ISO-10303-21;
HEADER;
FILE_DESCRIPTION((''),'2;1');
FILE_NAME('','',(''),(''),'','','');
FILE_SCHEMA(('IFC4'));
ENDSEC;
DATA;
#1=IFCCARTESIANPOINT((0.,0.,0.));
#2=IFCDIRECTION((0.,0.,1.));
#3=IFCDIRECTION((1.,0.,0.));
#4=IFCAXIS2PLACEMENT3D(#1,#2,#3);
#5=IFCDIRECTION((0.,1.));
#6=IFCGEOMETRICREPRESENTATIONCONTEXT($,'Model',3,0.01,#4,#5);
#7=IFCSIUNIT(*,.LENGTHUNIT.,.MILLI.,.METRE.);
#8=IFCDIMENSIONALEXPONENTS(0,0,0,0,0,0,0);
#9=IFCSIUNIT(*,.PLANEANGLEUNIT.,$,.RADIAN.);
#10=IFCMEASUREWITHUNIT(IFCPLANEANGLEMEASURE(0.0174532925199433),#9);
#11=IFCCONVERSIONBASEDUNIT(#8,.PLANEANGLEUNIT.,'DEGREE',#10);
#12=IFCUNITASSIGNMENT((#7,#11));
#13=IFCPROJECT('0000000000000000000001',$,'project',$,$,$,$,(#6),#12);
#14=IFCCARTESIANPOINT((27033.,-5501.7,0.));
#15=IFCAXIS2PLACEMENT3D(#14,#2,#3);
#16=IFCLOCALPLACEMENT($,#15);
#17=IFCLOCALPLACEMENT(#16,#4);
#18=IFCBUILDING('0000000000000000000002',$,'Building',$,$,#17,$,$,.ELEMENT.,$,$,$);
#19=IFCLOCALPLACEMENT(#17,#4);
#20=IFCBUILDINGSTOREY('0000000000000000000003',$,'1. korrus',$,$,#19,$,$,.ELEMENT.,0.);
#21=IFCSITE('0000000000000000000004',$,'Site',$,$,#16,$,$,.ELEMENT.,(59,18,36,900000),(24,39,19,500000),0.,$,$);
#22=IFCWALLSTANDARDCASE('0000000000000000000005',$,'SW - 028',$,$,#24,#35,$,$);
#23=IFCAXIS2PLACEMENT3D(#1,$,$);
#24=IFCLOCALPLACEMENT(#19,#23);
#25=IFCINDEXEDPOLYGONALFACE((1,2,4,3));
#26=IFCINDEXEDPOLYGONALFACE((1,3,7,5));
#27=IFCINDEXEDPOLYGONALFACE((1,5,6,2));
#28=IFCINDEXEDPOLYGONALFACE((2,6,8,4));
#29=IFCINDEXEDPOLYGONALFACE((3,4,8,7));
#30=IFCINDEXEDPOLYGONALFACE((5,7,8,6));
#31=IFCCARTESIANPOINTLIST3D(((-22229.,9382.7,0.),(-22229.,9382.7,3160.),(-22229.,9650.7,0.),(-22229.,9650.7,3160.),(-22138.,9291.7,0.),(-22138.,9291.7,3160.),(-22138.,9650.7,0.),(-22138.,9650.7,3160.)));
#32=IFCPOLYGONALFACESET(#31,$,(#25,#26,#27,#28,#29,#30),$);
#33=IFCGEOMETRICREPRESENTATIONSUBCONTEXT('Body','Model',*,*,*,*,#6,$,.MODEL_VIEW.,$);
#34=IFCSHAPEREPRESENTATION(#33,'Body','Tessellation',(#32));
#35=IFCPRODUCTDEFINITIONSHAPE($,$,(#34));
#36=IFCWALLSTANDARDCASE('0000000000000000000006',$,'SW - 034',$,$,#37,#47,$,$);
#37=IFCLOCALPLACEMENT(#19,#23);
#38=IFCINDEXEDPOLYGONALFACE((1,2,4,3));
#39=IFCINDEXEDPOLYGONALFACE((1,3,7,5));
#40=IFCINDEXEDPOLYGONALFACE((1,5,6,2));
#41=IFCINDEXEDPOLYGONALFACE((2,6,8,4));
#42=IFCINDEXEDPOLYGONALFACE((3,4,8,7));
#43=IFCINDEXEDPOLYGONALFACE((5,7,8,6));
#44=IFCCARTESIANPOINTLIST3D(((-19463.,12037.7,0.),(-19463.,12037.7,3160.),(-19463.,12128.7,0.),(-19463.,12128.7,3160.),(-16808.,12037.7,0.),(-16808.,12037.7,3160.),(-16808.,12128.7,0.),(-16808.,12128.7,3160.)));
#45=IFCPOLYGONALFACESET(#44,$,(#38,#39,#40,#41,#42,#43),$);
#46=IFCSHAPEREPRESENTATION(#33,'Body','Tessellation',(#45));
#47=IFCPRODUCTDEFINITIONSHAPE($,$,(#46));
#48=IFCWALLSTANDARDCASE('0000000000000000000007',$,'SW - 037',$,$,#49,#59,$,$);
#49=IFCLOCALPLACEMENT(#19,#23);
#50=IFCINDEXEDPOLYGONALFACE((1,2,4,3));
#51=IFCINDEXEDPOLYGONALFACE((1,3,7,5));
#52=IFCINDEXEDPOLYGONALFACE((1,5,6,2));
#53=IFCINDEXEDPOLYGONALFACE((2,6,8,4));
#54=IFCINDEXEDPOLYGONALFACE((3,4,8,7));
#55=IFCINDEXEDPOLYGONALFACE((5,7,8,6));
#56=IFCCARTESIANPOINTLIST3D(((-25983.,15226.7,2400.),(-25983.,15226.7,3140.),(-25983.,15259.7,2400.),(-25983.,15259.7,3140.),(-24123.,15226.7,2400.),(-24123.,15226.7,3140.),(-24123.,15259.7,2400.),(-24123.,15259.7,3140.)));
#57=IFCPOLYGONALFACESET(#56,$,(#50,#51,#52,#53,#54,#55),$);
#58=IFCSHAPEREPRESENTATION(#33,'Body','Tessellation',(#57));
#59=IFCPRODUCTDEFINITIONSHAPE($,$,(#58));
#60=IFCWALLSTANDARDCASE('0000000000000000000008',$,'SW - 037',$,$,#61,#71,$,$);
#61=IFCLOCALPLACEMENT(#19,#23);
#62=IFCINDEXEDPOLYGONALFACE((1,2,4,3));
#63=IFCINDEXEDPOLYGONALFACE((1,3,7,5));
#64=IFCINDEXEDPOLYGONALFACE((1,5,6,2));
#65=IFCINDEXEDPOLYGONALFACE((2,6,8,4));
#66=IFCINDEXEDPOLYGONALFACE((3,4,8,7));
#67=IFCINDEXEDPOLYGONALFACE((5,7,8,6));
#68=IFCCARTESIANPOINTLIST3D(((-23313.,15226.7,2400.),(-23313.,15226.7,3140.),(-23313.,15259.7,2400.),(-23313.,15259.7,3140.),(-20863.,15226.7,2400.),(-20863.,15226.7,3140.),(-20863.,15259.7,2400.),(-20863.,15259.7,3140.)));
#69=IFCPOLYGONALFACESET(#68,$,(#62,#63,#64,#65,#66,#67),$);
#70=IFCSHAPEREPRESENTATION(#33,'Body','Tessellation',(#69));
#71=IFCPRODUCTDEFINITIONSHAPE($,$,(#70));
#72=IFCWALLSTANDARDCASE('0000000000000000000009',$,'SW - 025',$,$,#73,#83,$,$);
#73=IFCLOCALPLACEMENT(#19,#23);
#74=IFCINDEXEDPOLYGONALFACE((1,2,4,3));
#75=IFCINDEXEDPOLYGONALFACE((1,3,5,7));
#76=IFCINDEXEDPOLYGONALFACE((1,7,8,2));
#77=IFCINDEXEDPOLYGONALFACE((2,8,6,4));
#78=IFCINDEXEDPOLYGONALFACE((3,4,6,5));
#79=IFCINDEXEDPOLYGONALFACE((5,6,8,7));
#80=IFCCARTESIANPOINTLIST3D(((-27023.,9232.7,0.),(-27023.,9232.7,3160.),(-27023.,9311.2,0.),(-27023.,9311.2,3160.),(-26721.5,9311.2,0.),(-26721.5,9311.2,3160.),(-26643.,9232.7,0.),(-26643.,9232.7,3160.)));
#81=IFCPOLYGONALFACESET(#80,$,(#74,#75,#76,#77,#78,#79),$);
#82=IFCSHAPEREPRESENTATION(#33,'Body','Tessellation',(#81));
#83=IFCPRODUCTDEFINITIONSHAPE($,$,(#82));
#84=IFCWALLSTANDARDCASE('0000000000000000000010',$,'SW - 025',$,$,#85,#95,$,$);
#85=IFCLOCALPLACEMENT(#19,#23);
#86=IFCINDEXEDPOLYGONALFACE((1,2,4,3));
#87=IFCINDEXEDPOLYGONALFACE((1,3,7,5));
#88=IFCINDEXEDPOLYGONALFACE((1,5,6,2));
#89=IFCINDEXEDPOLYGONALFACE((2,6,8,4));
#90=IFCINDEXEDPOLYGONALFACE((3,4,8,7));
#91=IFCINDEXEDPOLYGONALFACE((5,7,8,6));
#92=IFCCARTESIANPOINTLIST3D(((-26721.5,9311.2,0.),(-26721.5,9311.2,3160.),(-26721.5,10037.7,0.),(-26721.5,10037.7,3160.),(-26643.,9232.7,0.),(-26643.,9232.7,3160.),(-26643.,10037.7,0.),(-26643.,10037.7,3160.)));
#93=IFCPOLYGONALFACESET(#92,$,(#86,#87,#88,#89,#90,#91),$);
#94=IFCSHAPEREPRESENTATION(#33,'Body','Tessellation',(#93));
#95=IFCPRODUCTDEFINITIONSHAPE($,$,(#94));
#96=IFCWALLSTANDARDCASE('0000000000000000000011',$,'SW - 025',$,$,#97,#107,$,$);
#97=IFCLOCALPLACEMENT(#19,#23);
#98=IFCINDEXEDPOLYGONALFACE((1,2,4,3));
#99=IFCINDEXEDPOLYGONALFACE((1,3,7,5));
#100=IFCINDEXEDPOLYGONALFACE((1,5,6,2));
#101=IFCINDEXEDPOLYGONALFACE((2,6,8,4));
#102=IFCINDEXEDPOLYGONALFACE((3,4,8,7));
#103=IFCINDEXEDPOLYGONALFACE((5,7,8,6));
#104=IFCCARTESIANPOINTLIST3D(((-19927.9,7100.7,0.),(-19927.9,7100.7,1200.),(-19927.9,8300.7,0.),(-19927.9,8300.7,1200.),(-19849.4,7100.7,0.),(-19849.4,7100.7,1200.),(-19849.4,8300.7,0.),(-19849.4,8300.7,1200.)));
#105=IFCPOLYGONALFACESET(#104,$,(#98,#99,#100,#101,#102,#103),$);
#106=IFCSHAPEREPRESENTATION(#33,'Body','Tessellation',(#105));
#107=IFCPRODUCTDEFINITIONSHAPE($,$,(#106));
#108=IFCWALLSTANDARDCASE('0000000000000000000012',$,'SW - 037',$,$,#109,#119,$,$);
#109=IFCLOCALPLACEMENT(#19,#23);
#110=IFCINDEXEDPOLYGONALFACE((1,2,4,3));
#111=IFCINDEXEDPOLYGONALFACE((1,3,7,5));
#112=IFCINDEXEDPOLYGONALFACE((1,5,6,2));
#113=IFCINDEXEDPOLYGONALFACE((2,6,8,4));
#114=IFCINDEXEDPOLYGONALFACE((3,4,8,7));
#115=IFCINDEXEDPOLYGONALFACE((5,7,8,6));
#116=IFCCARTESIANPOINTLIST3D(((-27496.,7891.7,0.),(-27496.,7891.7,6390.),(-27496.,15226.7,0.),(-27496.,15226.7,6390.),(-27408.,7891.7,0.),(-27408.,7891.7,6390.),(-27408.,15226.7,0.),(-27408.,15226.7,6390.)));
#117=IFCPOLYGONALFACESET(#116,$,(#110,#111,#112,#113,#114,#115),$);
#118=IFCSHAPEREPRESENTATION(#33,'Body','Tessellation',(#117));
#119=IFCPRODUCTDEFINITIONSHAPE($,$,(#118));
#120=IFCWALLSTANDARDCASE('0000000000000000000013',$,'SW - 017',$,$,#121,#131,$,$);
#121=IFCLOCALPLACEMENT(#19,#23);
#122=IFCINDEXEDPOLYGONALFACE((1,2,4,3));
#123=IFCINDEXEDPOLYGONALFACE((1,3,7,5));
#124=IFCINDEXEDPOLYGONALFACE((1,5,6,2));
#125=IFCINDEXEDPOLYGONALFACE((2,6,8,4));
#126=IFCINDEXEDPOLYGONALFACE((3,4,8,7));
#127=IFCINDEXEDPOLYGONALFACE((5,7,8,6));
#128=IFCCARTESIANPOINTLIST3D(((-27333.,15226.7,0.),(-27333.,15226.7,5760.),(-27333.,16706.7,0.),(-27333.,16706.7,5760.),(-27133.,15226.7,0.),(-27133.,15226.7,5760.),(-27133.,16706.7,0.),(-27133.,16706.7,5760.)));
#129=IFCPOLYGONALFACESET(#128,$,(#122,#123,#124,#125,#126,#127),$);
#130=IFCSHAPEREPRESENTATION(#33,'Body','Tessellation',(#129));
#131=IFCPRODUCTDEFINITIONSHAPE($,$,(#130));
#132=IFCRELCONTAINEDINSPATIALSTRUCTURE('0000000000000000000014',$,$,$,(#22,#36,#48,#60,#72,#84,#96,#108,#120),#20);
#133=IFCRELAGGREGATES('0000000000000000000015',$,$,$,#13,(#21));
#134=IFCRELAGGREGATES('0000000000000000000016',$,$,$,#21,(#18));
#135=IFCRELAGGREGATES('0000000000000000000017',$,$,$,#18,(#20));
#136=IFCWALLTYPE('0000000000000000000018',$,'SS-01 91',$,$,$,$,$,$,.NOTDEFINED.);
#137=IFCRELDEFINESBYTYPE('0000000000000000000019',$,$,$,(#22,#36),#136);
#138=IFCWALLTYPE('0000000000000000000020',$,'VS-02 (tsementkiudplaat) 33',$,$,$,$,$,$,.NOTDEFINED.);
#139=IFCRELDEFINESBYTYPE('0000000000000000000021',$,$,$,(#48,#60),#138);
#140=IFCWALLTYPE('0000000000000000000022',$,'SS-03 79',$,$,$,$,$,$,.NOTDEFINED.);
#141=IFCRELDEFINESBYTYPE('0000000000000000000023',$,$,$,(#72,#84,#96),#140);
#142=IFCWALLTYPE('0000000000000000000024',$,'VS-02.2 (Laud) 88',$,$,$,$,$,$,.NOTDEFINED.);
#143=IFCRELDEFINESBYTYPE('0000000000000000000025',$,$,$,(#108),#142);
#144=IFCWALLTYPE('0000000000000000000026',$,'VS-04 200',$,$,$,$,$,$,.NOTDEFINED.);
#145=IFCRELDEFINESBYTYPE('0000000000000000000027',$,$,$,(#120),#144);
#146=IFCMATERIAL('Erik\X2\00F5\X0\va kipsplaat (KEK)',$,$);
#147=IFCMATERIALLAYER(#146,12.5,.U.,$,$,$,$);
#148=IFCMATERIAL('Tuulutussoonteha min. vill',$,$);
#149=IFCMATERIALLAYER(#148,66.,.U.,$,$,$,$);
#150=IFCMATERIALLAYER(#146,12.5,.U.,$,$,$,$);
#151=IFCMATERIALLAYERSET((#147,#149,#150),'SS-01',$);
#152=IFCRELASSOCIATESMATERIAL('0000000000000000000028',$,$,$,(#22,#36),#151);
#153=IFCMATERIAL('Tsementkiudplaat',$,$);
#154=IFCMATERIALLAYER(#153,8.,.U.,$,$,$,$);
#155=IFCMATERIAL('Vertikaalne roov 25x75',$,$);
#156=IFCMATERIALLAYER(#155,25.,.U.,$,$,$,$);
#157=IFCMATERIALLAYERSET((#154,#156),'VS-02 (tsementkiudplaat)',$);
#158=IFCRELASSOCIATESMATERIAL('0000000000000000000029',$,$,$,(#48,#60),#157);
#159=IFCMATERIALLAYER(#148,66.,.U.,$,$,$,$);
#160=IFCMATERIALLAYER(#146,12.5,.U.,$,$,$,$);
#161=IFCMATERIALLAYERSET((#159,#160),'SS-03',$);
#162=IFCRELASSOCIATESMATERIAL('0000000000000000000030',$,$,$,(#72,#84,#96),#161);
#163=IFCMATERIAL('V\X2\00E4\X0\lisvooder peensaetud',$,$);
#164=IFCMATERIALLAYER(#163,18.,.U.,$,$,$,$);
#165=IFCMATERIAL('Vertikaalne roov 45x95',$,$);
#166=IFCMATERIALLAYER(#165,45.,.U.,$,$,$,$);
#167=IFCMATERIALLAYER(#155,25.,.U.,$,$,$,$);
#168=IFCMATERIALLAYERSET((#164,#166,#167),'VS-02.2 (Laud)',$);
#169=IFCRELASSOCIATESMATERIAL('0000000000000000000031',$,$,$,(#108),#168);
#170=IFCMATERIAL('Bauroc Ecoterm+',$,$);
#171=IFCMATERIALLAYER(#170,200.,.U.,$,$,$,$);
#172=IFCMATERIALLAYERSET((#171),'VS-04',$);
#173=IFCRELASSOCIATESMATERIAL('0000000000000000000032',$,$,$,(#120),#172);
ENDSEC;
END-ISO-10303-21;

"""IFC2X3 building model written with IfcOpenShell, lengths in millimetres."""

from ifc_helpers import new_model, entity, si_unit, converted_unit, direction, frame, origin_with_axes, place, context, subcontext, project, spatial, polyline, outline, extrude, material, layer, layer_set, layer_usage, type_object, element, save


model = new_model("IFC2X3")

# Units and contexts
model_context = context("Model", 3, precision=0.01, world=origin_with_axes(), true_north=direction((0.0, 1.0)))
body_context = subcontext(model_context, "Body", "Model", "MODEL_VIEW")
ifc_project = project(units=[si_unit("LENGTHUNIT", "METRE", prefix="MILLI"), converted_unit("PLANEANGLEUNIT", "DEGREE", entity("IfcPlaneAngleMeasure", 0.0174532925199433), si_unit("PLANEANGLEUNIT", "RADIAN"), dimensions=[0, 0, 0, 0, 0, 0, 0])], contexts=[model_context])

# Site, building, storey
site_placement = place(None, frame((27033.0, -5501.7, 0.0), z_axis=(0.0, 0.0, 1.0), x_axis=(1.0, 0.0, 0.0)))
site = spatial("IfcSite", under=ifc_project, at=site_placement, Name="Site", CompositionType="ELEMENT", RefLatitude=(59, 18, 36, 900000), RefLongitude=(24, 39, 19, 500000), RefElevation=0.0)
building_placement = place(site_placement, origin_with_axes())
building = spatial("IfcBuilding", under=site, at=building_placement, Name="Building", CompositionType="ELEMENT")
storey_placement = place(building_placement, origin_with_axes())
storey = spatial("IfcBuildingStorey", under=building, at=storey_placement, Name="1. korrus", CompositionType="ELEMENT", Elevation=0.0)

# Shared definitions
ifc_material_1 = material(Name="Bauroc Ecoterm+")

# Walls
ifc_material_2 = material(Name="Vertikaalne roov 45x95")
ifc_material_3 = material(Name="Erikõva kipsplaat (KEK)")
ifc_layer_1 = layer(ifc_material_3, 12.5, ventilated="UNKNOWN")
ifc_material_4 = material(Name="Tuulutussoonteha min. vill")
ifc_layer_2 = layer(ifc_material_4, 66.0, ventilated="UNKNOWN")
ifc_layer_3 = layer(ifc_material_3, 12.5, ventilated="UNKNOWN")
ifc_layer_set_1 = layer_set([ifc_layer_1, ifc_layer_2, ifc_layer_3], Name="SS-01")
wall_type_1 = type_object("IfcWallType", Name="SS-01 91", PredefinedType="NOTDEFINED")
ifc_layer_usage_1 = layer_usage(ifc_layer_set_1, "AXIS2", "NEGATIVE", 91.0)
wall_1_placement = place(storey_placement, frame((-22138.0, 9291.7, 0.0), z_axis=(0.0, 0.0, 1.0), x_axis=(0.0, 1.0, 0.0)))
element("IfcWallStandardCase", 1, at=wall_1_placement, inside=storey, type_object=wall_type_1, material=ifc_layer_usage_1, Name="SW - 028", context=body_context, shape_type="SweptSolid", body=[
    extrude(outline(polyline([(0.0, 0.0), (359.0, 0.0), (359.0, 91.0), (91.0, 91.0), (0.0, 0.0)])), origin_with_axes(), (0.0, 0.0, 1.0), 3160.0),
])
ifc_layer_usage_2 = layer_usage(ifc_layer_set_1, "AXIS2", "NEGATIVE", 91.0)
wall_2_placement = place(storey_placement, frame((-19463.0, 12037.7, 0.0), z_axis=(0.0, 0.0, 1.0), x_axis=(1.0, 0.0, 0.0)))
element("IfcWallStandardCase", 2, at=wall_2_placement, inside=storey, type_object=wall_type_1, material=ifc_layer_usage_2, Name="SW - 034", context=body_context, shape_type="SweptSolid", body=[
    extrude(outline(polyline([(0.0, 0.0), (2655.0, 0.0), (2655.0, 91.0), (0.0, 91.0), (0.0, 0.0)])), origin_with_axes(), (0.0, 0.0, 1.0), 3160.0),
])
ifc_material_5 = material(Name="Tsementkiudplaat")
ifc_layer_4 = layer(ifc_material_5, 8.0, ventilated="UNKNOWN")
ifc_material_6 = material(Name="Vertikaalne roov 25x75")
ifc_layer_5 = layer(ifc_material_6, 25.0, ventilated="UNKNOWN")
ifc_layer_set_2 = layer_set([ifc_layer_4, ifc_layer_5], Name="VS-02 (tsementkiudplaat)")
ifc_layer_usage_3 = layer_usage(ifc_layer_set_2, "AXIS2", "POSITIVE", -33.0)
wall_type_2 = type_object("IfcWallType", Name="VS-02 (tsementkiudplaat) 33", PredefinedType="NOTDEFINED")
wall_3_placement = place(storey_placement, frame((-24123.0, 15226.7, 2400.0), z_axis=(0.0, 0.0, 1.0), x_axis=(-1.0, -0.000005, 0.0)))
element("IfcWallStandardCase", 3, at=wall_3_placement, inside=storey, type_object=wall_type_2, material=ifc_layer_usage_3, Name="SW - 037", context=body_context, shape_type="SweptSolid", body=[
    extrude(outline(polyline([(0.0, -33.0), (1860.0, -33.0), (1860.0, 0.0), (0.0, 0.0), (0.0, -33.0)])), origin_with_axes(), (0.0, 0.0, 1.0), 740.0),
])
ifc_layer_usage_4 = layer_usage(ifc_layer_set_2, "AXIS2", "POSITIVE", -33.0)
wall_4_placement = place(storey_placement, frame((-20863.0, 15226.7, 2400.0), z_axis=(0.0, 0.0, 1.0), x_axis=(-1.0, -0.000003, 0.0)))
element("IfcWallStandardCase", 4, at=wall_4_placement, inside=storey, type_object=wall_type_2, material=ifc_layer_usage_4, Name="SW - 037", context=body_context, shape_type="SweptSolid", body=[
    extrude(outline(polyline([(0.0, -33.0), (2450.0, -33.0), (2450.0, 0.0), (0.0, 0.0), (0.0, -33.0)])), origin_with_axes(), (0.0, 0.0, 1.0), 740.0),
])
ifc_layer_6 = layer(ifc_material_4, 66.0, ventilated="UNKNOWN")
ifc_layer_7 = layer(ifc_material_3, 12.5, ventilated="UNKNOWN")
ifc_layer_set_3 = layer_set([ifc_layer_6, ifc_layer_7], Name="SS-03")
ifc_layer_usage_5 = layer_usage(ifc_layer_set_3, "AXIS2", "POSITIVE", -78.5)
wall_type_3 = type_object("IfcWallType", Name="SS-03 79", PredefinedType="NOTDEFINED")
wall_5_placement = place(storey_placement, frame((-26643.0, 9232.7, 0.0), z_axis=(0.0, 0.0, 1.0), x_axis=(-1.0, 0.0, 0.0)))
element("IfcWallStandardCase", 5, at=wall_5_placement, inside=storey, type_object=wall_type_3, material=ifc_layer_usage_5, Name="SW - 025", context=body_context, shape_type="SweptSolid", body=[
    extrude(outline(polyline([(78.5, -78.5), (380.0, -78.5), (380.0, 0.0), (0.0, 0.0), (78.5, -78.5)])), origin_with_axes(), (0.0, 0.0, 1.0), 3160.0),
])
ifc_layer_usage_6 = layer_usage(ifc_layer_set_3, "AXIS2", "NEGATIVE", 78.5)
wall_6_placement = place(storey_placement, frame((-26643.0, 9232.7, 0.0), z_axis=(0.0, 0.0, 1.0), x_axis=(0.0, 1.0, 0.0)))
element("IfcWallStandardCase", 6, at=wall_6_placement, inside=storey, type_object=wall_type_3, material=ifc_layer_usage_6, Name="SW - 025", context=body_context, shape_type="SweptSolid", body=[
    extrude(outline(polyline([(0.0, 0.0), (805.0, 0.0), (805.0, 78.5), (78.5, 78.5), (0.0, 0.0)])), origin_with_axes(), (0.0, 0.0, 1.0), 3160.0),
])
ifc_layer_usage_7 = layer_usage(ifc_layer_set_3, "AXIS2", "POSITIVE", -78.5)
wall_7_placement = place(storey_placement, frame((-19927.9, 7100.7, 0.0), z_axis=(0.0, 0.0, 1.0), x_axis=(0.0, 1.0, 0.0)))
element("IfcWallStandardCase", 7, at=wall_7_placement, inside=storey, type_object=wall_type_3, material=ifc_layer_usage_7, Name="SW - 025", context=body_context, shape_type="SweptSolid", body=[
    extrude(outline(polyline([(0.0, -78.5), (1200.0, -78.5), (1200.0, 0.0), (0.0, 0.0), (0.0, -78.5)])), origin_with_axes(), (0.0, 0.0, 1.0), 1200.0),
])
ifc_material_7 = material(Name="Välisvooder peensaetud")
ifc_layer_8 = layer(ifc_material_7, 18.0, ventilated="UNKNOWN")
ifc_layer_9 = layer(ifc_material_2, 45.0, ventilated="UNKNOWN")
ifc_layer_10 = layer(ifc_material_6, 25.0, ventilated="UNKNOWN")
ifc_layer_set_4 = layer_set([ifc_layer_8, ifc_layer_9, ifc_layer_10], Name="VS-02.2 (Laud)")
ifc_layer_usage_8 = layer_usage(ifc_layer_set_4, "AXIS2", "POSITIVE", -88.0)
wall_type_4 = type_object("IfcWallType", Name="VS-02.2 (Laud) 88", PredefinedType="NOTDEFINED")
wall_8_placement = place(storey_placement, frame((-27408.0, 15226.7, 0.0), z_axis=(0.0, 0.0, 1.0), x_axis=(0.000003, -1.0, 0.0)))
element("IfcWallStandardCase", 8, at=wall_8_placement, inside=storey, type_object=wall_type_4, material=ifc_layer_usage_8, Name="SW - 037", context=body_context, shape_type="SweptSolid", body=[
    extrude(outline(polyline([(0.0, -88.0), (7335.0, -88.0), (7335.0, 0.0), (0.0, 0.0), (0.0, -88.0)])), origin_with_axes(), (0.0, 0.0, 1.0), 6390.0),
])
ifc_layer_11 = layer(ifc_material_1, 200.0, ventilated="UNKNOWN")
ifc_layer_set_5 = layer_set([ifc_layer_11], Name="VS-04")
ifc_layer_usage_9 = layer_usage(ifc_layer_set_5, "AXIS2", "NEGATIVE", 0.0)
wall_type_5 = type_object("IfcWallType", Name="VS-04 200", PredefinedType="NOTDEFINED")
wall_9_placement = place(storey_placement, frame((-27333.0, 15226.7, 0.0), z_axis=(0.0, 0.0, 1.0), x_axis=(0.0, 1.0, 0.0)))
element("IfcWallStandardCase", 9, at=wall_9_placement, inside=storey, type_object=wall_type_5, material=ifc_layer_usage_9, Name="SW - 017", context=body_context, shape_type="SweptSolid", body=[
    extrude(outline(polyline([(0.0, -200.0), (1480.0, -200.0), (1480.0, 0.0), (0.0, 0.0), (0.0, -200.0)])), origin_with_axes(), (0.0, 0.0, 1.0), 5760.0),
])

save(model, "model.ifc")
